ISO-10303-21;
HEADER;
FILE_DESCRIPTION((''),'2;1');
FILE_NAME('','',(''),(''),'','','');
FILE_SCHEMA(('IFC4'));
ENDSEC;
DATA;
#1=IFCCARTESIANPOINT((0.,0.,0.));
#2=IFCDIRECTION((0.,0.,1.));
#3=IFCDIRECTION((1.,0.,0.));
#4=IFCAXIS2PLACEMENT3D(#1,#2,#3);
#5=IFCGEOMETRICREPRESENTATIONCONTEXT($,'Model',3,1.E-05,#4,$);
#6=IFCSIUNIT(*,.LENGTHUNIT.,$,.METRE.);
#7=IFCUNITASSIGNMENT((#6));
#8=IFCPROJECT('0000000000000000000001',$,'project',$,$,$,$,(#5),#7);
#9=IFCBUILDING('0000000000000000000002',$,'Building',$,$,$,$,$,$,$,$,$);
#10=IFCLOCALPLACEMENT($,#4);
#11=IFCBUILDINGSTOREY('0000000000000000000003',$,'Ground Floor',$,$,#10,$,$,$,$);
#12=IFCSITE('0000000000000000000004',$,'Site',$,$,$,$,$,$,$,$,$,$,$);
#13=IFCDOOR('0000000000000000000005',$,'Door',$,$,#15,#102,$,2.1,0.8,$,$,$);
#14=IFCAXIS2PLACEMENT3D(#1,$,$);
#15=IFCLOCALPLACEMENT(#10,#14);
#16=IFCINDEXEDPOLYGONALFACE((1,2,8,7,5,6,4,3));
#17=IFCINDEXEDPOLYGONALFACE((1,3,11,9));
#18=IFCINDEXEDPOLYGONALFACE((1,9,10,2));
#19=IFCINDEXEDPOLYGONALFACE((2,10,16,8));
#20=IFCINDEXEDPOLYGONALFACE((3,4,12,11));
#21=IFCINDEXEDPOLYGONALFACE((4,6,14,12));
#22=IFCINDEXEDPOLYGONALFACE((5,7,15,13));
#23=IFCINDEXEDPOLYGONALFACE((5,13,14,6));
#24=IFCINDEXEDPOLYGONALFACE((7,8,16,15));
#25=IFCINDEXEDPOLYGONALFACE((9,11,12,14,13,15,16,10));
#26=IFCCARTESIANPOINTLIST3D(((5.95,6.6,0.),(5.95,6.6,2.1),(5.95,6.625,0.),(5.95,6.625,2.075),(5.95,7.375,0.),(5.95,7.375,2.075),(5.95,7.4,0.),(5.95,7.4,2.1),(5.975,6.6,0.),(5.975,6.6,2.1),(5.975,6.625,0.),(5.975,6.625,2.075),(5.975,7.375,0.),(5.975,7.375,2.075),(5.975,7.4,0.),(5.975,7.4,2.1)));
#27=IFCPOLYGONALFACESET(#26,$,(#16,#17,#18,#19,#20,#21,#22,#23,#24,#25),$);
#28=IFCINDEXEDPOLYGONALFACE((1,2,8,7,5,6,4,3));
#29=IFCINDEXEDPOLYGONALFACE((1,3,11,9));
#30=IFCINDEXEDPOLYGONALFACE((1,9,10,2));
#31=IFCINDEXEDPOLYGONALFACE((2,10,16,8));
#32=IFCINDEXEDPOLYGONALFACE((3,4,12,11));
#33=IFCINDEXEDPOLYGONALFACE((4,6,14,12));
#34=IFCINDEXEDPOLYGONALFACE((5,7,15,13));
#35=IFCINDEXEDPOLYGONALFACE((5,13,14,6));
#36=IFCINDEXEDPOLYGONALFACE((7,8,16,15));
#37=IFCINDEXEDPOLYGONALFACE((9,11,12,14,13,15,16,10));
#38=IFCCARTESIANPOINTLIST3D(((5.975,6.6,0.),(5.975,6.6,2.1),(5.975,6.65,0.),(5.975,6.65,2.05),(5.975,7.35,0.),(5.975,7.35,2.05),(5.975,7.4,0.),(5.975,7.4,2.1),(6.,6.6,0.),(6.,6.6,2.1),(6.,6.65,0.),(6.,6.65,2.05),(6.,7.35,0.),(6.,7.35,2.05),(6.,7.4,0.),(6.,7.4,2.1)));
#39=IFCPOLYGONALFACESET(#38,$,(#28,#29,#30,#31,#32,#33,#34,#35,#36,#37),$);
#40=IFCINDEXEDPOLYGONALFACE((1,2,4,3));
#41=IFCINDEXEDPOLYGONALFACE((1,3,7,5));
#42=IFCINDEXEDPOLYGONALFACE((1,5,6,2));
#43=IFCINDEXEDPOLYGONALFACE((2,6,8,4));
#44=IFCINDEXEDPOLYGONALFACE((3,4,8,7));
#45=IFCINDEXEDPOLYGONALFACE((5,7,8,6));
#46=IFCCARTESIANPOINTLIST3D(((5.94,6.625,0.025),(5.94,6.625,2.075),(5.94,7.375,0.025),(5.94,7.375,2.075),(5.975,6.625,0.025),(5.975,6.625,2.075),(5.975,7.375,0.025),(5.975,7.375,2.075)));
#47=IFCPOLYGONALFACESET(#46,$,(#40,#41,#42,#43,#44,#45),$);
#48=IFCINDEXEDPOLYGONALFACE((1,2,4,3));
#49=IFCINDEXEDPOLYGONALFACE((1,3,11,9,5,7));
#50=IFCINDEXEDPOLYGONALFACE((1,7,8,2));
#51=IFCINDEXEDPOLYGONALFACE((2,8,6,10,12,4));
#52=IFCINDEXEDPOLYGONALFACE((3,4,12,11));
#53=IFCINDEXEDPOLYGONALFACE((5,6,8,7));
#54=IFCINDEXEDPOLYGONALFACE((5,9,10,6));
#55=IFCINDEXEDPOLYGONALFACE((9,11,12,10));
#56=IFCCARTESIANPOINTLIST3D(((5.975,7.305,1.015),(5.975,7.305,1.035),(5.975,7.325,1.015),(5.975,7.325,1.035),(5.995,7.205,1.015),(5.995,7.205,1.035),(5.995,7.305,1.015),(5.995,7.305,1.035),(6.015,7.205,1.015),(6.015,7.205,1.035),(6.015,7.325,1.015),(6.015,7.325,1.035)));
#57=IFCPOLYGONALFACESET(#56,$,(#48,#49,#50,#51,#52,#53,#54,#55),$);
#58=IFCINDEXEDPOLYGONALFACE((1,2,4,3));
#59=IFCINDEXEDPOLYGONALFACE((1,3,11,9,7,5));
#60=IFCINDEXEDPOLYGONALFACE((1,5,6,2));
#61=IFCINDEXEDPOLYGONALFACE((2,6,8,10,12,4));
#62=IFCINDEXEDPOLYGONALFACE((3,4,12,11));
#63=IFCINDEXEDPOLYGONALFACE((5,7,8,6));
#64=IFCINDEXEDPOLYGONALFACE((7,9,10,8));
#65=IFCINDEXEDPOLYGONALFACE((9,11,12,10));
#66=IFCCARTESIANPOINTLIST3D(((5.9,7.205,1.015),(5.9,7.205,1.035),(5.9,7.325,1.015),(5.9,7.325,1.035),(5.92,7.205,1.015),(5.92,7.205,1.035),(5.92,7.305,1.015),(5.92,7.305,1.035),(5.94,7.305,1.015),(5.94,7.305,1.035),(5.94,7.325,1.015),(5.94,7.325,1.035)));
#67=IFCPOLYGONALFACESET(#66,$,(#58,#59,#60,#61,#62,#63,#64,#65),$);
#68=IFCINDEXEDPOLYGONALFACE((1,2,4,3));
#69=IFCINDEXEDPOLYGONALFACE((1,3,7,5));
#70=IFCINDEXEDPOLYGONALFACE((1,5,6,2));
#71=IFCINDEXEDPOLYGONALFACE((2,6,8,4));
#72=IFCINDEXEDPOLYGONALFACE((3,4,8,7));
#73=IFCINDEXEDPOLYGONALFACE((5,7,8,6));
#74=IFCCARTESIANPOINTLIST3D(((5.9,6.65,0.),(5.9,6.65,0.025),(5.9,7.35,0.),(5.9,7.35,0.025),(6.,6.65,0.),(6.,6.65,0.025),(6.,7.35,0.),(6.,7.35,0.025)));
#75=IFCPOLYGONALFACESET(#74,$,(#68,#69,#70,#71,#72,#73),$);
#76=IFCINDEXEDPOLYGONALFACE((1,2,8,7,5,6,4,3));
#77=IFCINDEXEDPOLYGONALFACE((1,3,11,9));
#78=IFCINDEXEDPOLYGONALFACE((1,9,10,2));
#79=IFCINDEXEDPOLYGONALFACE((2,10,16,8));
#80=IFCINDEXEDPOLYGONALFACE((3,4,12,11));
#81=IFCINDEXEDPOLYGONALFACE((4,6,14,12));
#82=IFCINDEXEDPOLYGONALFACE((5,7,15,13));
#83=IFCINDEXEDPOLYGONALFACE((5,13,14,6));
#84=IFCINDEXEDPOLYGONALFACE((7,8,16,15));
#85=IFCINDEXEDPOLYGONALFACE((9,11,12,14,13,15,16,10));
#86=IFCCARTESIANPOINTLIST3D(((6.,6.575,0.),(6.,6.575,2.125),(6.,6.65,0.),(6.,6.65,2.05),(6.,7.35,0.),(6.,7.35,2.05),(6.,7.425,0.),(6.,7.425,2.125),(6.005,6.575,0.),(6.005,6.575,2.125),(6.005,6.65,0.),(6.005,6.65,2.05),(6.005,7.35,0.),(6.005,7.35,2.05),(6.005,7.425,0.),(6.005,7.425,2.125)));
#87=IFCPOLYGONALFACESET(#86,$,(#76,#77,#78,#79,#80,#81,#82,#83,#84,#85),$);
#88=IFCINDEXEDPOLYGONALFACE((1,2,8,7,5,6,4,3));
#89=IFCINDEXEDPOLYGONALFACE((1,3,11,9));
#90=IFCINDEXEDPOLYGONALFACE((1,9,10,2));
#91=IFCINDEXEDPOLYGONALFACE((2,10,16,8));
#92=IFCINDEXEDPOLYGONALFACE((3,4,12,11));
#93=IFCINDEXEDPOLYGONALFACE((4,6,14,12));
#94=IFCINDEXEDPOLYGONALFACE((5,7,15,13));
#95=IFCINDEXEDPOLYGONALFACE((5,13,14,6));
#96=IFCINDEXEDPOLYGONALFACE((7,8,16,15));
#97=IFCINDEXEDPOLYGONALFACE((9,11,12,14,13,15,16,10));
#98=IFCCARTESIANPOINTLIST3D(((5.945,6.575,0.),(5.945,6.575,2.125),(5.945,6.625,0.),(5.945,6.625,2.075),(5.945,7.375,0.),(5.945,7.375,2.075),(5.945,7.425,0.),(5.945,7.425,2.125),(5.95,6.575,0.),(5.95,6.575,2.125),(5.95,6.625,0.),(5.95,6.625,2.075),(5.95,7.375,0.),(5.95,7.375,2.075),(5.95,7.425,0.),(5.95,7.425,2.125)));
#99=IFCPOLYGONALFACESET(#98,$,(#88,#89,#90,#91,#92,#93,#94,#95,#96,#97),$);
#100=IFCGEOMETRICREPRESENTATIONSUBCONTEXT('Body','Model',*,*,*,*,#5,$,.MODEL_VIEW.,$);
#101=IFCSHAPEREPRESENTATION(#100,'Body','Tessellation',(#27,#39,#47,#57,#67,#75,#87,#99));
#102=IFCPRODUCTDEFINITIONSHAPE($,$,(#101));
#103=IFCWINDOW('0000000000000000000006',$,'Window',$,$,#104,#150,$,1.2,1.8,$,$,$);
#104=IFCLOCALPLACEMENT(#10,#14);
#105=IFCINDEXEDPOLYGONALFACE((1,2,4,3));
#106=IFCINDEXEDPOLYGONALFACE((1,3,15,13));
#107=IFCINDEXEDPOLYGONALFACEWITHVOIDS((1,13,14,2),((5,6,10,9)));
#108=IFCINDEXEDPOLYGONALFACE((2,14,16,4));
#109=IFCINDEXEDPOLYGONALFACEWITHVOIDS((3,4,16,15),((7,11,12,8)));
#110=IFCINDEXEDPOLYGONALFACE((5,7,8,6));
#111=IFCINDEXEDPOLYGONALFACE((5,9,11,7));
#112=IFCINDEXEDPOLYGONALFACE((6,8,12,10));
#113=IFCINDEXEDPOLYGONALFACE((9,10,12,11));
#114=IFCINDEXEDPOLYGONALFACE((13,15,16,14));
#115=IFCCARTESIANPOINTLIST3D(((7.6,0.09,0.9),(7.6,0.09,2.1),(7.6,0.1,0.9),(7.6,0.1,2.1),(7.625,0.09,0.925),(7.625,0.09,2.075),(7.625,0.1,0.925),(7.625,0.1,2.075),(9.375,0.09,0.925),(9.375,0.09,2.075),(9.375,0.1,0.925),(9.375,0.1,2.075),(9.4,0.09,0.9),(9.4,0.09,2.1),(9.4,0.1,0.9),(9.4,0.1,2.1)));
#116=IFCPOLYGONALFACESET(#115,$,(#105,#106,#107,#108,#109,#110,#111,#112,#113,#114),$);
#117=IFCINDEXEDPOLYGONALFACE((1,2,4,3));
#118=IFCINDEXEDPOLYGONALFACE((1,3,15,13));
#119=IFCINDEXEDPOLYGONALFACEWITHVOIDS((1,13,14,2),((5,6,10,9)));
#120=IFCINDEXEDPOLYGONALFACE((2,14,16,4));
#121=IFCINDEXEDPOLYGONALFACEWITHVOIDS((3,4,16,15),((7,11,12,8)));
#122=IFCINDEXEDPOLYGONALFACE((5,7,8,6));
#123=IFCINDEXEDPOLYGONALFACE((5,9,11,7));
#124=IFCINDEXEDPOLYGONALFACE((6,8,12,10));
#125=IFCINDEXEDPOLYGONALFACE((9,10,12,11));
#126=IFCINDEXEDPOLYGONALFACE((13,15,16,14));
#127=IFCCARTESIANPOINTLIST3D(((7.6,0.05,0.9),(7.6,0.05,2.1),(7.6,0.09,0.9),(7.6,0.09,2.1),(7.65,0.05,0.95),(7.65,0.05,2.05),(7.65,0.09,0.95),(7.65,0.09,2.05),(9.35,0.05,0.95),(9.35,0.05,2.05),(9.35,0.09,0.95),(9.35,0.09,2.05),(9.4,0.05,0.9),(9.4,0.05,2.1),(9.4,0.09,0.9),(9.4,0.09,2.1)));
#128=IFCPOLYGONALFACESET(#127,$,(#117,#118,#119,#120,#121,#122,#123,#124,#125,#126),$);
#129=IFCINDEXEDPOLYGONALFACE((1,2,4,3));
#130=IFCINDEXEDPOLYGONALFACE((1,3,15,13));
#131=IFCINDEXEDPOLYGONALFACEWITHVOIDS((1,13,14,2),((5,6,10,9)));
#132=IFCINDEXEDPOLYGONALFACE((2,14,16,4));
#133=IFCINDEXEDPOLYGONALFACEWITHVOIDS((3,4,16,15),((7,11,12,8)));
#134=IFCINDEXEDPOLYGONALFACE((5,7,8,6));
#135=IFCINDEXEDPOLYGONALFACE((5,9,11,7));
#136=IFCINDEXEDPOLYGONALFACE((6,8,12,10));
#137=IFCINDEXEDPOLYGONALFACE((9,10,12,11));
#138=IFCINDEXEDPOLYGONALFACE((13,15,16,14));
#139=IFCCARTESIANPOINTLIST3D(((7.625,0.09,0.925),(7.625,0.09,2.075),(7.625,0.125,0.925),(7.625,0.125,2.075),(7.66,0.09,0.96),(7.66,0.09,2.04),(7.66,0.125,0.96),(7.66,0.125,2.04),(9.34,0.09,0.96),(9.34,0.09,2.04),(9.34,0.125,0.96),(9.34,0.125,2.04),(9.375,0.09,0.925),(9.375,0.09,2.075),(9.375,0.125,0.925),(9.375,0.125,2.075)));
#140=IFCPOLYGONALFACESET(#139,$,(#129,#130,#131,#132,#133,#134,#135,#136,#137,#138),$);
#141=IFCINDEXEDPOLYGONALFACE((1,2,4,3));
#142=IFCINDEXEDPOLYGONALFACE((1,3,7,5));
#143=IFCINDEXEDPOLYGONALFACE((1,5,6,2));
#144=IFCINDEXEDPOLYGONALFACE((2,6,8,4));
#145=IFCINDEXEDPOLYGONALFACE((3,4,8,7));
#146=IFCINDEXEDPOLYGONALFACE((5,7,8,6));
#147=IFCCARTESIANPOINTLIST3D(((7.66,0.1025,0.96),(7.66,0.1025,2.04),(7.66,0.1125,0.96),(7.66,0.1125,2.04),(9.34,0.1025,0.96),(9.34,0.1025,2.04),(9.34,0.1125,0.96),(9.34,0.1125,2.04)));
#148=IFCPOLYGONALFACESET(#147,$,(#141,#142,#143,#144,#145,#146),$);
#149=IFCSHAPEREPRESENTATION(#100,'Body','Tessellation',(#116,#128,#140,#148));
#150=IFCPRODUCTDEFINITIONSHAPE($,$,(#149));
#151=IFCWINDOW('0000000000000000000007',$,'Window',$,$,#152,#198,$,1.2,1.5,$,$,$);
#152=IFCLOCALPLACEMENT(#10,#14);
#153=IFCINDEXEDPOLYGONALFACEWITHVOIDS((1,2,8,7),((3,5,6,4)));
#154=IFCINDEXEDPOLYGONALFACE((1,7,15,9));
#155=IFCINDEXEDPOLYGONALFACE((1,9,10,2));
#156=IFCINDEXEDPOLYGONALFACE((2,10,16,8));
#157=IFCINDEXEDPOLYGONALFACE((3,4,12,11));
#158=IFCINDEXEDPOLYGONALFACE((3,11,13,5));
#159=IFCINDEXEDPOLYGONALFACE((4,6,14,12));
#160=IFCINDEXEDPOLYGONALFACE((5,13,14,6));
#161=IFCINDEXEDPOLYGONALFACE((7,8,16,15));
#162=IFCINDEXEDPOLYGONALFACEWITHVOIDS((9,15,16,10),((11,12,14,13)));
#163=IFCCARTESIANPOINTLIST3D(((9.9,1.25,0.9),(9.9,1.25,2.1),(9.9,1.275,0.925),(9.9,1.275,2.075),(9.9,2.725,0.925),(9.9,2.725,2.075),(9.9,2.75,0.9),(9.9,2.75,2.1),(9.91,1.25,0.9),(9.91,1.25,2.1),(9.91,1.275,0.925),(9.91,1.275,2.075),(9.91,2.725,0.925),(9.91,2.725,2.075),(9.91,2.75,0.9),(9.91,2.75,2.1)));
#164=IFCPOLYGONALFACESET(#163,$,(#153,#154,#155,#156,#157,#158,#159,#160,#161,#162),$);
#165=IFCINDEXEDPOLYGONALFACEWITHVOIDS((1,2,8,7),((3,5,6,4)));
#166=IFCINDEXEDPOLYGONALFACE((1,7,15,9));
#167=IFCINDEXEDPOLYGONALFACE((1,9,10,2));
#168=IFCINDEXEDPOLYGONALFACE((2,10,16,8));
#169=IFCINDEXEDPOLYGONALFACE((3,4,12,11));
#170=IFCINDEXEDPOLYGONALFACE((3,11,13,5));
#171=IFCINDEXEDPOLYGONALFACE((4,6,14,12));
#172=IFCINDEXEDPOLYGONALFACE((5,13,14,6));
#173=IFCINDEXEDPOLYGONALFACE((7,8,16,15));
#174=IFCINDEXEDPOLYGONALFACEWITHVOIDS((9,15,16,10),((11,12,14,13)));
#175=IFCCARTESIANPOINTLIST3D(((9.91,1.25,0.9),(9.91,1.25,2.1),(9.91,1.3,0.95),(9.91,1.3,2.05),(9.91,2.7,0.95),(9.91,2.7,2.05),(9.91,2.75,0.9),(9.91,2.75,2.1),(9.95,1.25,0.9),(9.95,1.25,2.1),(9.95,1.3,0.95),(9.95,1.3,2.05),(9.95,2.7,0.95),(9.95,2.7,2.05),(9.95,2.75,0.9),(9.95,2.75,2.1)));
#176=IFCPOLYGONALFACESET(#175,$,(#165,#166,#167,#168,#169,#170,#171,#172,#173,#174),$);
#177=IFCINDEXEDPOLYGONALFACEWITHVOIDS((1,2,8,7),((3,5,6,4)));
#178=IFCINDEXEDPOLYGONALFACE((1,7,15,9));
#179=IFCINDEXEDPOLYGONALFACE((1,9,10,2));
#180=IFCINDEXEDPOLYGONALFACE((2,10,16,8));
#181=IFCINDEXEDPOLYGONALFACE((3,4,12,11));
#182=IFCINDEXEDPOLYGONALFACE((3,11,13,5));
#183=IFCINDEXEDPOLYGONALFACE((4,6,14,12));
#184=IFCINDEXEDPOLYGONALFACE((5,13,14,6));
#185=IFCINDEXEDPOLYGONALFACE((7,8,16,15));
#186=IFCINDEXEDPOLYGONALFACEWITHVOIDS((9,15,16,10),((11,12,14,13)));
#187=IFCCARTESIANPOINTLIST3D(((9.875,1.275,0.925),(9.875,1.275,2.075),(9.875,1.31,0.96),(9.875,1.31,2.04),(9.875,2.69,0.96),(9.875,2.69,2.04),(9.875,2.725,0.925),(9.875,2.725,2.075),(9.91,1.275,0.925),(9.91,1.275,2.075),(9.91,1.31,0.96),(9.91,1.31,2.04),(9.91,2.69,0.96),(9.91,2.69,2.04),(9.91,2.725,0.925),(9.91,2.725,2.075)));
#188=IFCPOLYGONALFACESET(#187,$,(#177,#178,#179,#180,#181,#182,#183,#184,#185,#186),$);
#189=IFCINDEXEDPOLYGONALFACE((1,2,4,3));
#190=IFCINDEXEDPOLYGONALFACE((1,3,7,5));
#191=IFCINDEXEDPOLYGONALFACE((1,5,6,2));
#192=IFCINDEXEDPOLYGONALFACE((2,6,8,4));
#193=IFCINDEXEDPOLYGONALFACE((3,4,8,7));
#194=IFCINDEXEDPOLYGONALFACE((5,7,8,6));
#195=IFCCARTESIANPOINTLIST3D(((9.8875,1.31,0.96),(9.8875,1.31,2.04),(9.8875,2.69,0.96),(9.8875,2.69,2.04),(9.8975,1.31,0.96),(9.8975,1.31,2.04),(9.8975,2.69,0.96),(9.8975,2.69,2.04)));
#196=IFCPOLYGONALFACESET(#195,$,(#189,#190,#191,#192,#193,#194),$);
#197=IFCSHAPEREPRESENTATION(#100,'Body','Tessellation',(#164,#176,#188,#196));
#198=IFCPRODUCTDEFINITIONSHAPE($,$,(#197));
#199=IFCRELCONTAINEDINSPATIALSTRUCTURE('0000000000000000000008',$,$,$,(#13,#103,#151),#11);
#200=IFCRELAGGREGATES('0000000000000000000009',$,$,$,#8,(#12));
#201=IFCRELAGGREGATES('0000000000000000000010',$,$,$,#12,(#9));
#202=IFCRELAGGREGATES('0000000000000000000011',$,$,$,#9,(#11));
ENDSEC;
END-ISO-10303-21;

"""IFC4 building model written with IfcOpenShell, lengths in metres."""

from ifc_helpers import new_model, si_unit, frame, origin_with_axes, place, context, subcontext, project, spatial, line, indexed_curve, outline, extrude, element, save


model = new_model("IFC4")

# Units and contexts
model_context = context("Model", 3, precision=1e-05, world=origin_with_axes())
body_context = subcontext(model_context, "Body", "Model", "MODEL_VIEW")
ifc_project = project(units=[si_unit("LENGTHUNIT", "METRE")], contexts=[model_context])

# Site, building, storey
site = spatial("IfcSite", under=ifc_project, Name="Site")
building = spatial("IfcBuilding", under=site, Name="Building")
storey_placement = place(None, origin_with_axes())
storey = spatial("IfcBuildingStorey", under=building, at=storey_placement, Name="Ground Floor")

# Door
door_1_placement = place(storey_placement, frame((6.0, 6.6, 0.0), z_axis=(0.0, 0.0, 1.0), x_axis=(0.0, 1.0, 0.0)))
element("IfcDoor", 1, at=door_1_placement, inside=storey, Name="Door", OverallHeight=2.1, OverallWidth=0.8, context=body_context, shape_type="SweptSolid", body=[
    extrude(outline(indexed_curve([(0.0, 0.0), (0.0, 2.1), (0.8, 2.1), (0.8, 0.0), (0.775, 0.0), (0.775, 2.075), (0.025, 2.075), (0.025, 0.0)], segments=[line(1, 2, 3, 4, 5, 6, 7, 8, 1)])), frame((0.0, 0.025, 0.0), z_axis=(0.0, -1.0, 0.0), x_axis=(1.0, 0.0, 0.0)), (0.0, 0.0, -1.0), 0.025),
    extrude(outline(indexed_curve([(0.0, 0.0), (0.0, 2.1), (0.8, 2.1), (0.8, 0.0), (0.75, 0.0), (0.75, 2.05), (0.05, 2.05), (0.05, 0.0)], segments=[line(1, 2, 3, 4, 5, 6, 7, 8, 1)])), frame((0.0, 0.0, 0.0), z_axis=(0.0, -1.0, 0.0), x_axis=(1.0, 0.0, 0.0)), (0.0, 0.0, -1.0), 0.025),
    extrude(outline(indexed_curve([(0.0, 0.0), (0.75, 0.0), (0.75, 0.035), (0.0, 0.035)], segments=[line(1, 2, 3, 4, 1)])), frame((0.025, 0.025, 0.025), z_axis=(0.0, 0.0, 1.0), x_axis=(1.0, 0.0, 0.0)), (0.0, 0.0, 1.0), 2.05),
    extrude(outline(indexed_curve([(0.0, 0.0), (0.0, -0.04), (-0.12, -0.04), (-0.12, -0.02), (-0.02, -0.02), (-0.02, 0.0)], segments=[line(1, 2, 3, 4, 5, 6, 1)])), frame((0.725, 0.025, 1.015), z_axis=(0.0, 0.0, 1.0), x_axis=(1.0, 0.0, 0.0)), (0.0, 0.0, 1.0), 0.02),
    extrude(outline(indexed_curve([(0.0, 0.0), (0.0, 0.04), (-0.12, 0.04), (-0.12, 0.02), (-0.02, 0.02), (-0.02, 0.0)], segments=[line(1, 2, 3, 4, 5, 6, 1)])), frame((0.725, 0.06, 1.015), z_axis=(0.0, 0.0, 1.0), x_axis=(1.0, 0.0, 0.0)), (0.0, 0.0, 1.0), 0.02),
    extrude(outline(indexed_curve([(0.0, 0.0), (0.7, 0.0), (0.7, 0.1), (0.0, 0.1)], segments=[line(1, 2, 3, 4, 1)])), frame((0.05, 0.0, 0.0), z_axis=(0.0, 0.0, 1.0), x_axis=(1.0, 0.0, 0.0)), (0.0, 0.0, 1.0), 0.025),
    extrude(outline(indexed_curve([(0.0, 0.0), (0.0, 2.125), (0.85, 2.125), (0.85, 0.0), (0.775, 0.0), (0.775, 2.05), (0.075, 2.05), (0.075, 0.0)], segments=[line(1, 2, 3, 4, 5, 6, 7, 8, 1)])), frame((-0.025, -0.005, 0.0), z_axis=(0.0, -1.0, 0.0), x_axis=(1.0, 0.0, 0.0)), (0.0, 0.0, -1.0), 0.005),
    extrude(outline(indexed_curve([(0.0, 0.0), (0.0, 2.125), (0.85, 2.125), (0.85, 0.0), (0.8, 0.0), (0.8, 2.075), (0.05, 2.075), (0.05, 0.0)], segments=[line(1, 2, 3, 4, 5, 6, 7, 8, 1)])), frame((-0.025, 0.05, 0.0), z_axis=(0.0, -1.0, 0.0), x_axis=(1.0, 0.0, 0.0)), (0.0, 0.0, -1.0), 0.005),
])

# Windows
window_1_placement = place(storey_placement, frame((7.6, 0.0, 0.9), z_axis=(0.0, 0.0, 1.0), x_axis=(1.0, 0.0, 0.0)))
element("IfcWindow", 2, at=window_1_placement, inside=storey, Name="Window", OverallHeight=1.2, OverallWidth=1.8, context=body_context, shape_type="SweptSolid", body=[
    extrude(outline(indexed_curve([(0.0, 0.0), (1.8, 0.0), (1.8, 1.2), (0.0, 1.2)], segments=[line(1, 2, 3, 4, 1)]), holes=[indexed_curve([(0.025, 0.025), (1.775, 0.025), (1.775, 1.175), (0.025, 1.175)], segments=[line(1, 2, 3, 4, 1)])]), frame((0.0, 0.09, 0.0), z_axis=(0.0, -1.0, 0.0), x_axis=(1.0, 0.0, 0.0)), (0.0, 0.0, -1.0), 0.01),
    extrude(outline(indexed_curve([(0.0, 0.0), (1.8, 0.0), (1.8, 1.2), (0.0, 1.2)], segments=[line(1, 2, 3, 4, 1)]), holes=[indexed_curve([(0.05, 0.05), (1.75, 0.05), (1.75, 1.15), (0.05, 1.15)], segments=[line(1, 2, 3, 4, 1)])]), frame((0.0, 0.05, 0.0), z_axis=(0.0, -1.0, 0.0), x_axis=(1.0, 0.0, 0.0)), (0.0, 0.0, -1.0), 0.04),
    extrude(outline(indexed_curve([(0.0, 0.0), (1.75, 0.0), (1.75, 1.15), (0.0, 1.15)], segments=[line(1, 2, 3, 4, 1)]), holes=[indexed_curve([(0.035, 0.035), (1.715, 0.035), (1.715, 1.115), (0.035, 1.115)], segments=[line(1, 2, 3, 4, 1)])]), frame((0.025, 0.09, 0.025), z_axis=(0.0, -1.0, 0.0), x_axis=(1.0, 0.0, 0.0)), (0.0, 0.0, -1.0), 0.035),
    extrude(outline(indexed_curve([(0.035, 0.035), (1.715, 0.035), (1.715, 1.115), (0.035, 1.115)], segments=[line(1, 2, 3, 4, 1)])), frame((0.025, 0.1025, 0.025), z_axis=(0.0, -1.0, 0.0), x_axis=(1.0, 0.0, 0.0)), (0.0, 0.0, -1.0), 0.01),
])
window_2_placement = place(storey_placement, frame((10.0, 1.25, 0.9), z_axis=(0.0, 0.0, 1.0), x_axis=(0.0, 1.0, 0.0)))
element("IfcWindow", 3, at=window_2_placement, inside=storey, Name="Window", OverallHeight=1.2, OverallWidth=1.5, context=body_context, shape_type="SweptSolid", body=[
    extrude(outline(indexed_curve([(0.0, 0.0), (1.5, 0.0), (1.5, 1.2), (0.0, 1.2)], segments=[line(1, 2, 3, 4, 1)]), holes=[indexed_curve([(0.025, 0.025), (1.475, 0.025), (1.475, 1.175), (0.025, 1.175)], segments=[line(1, 2, 3, 4, 1)])]), frame((0.0, 0.09, 0.0), z_axis=(0.0, -1.0, 0.0), x_axis=(1.0, 0.0, 0.0)), (0.0, 0.0, -1.0), 0.01),
    extrude(outline(indexed_curve([(0.0, 0.0), (1.5, 0.0), (1.5, 1.2), (0.0, 1.2)], segments=[line(1, 2, 3, 4, 1)]), holes=[indexed_curve([(0.05, 0.05), (1.45, 0.05), (1.45, 1.15), (0.05, 1.15)], segments=[line(1, 2, 3, 4, 1)])]), frame((0.0, 0.05, 0.0), z_axis=(0.0, -1.0, 0.0), x_axis=(1.0, 0.0, 0.0)), (0.0, 0.0, -1.0), 0.04),
    extrude(outline(indexed_curve([(0.0, 0.0), (1.45, 0.0), (1.45, 1.15), (0.0, 1.15)], segments=[line(1, 2, 3, 4, 1)]), holes=[indexed_curve([(0.035, 0.035), (1.415, 0.035), (1.415, 1.115), (0.035, 1.115)], segments=[line(1, 2, 3, 4, 1)])]), frame((0.025, 0.09, 0.025), z_axis=(0.0, -1.0, 0.0), x_axis=(1.0, 0.0, 0.0)), (0.0, 0.0, -1.0), 0.035),
    extrude(outline(indexed_curve([(0.035, 0.035), (1.415, 0.035), (1.415, 1.115), (0.035, 1.115)], segments=[line(1, 2, 3, 4, 1)])), frame((0.025, 0.1025, 0.025), z_axis=(0.0, -1.0, 0.0), x_axis=(1.0, 0.0, 0.0)), (0.0, 0.0, -1.0), 0.01),
])

save(model, "model.ifc")
